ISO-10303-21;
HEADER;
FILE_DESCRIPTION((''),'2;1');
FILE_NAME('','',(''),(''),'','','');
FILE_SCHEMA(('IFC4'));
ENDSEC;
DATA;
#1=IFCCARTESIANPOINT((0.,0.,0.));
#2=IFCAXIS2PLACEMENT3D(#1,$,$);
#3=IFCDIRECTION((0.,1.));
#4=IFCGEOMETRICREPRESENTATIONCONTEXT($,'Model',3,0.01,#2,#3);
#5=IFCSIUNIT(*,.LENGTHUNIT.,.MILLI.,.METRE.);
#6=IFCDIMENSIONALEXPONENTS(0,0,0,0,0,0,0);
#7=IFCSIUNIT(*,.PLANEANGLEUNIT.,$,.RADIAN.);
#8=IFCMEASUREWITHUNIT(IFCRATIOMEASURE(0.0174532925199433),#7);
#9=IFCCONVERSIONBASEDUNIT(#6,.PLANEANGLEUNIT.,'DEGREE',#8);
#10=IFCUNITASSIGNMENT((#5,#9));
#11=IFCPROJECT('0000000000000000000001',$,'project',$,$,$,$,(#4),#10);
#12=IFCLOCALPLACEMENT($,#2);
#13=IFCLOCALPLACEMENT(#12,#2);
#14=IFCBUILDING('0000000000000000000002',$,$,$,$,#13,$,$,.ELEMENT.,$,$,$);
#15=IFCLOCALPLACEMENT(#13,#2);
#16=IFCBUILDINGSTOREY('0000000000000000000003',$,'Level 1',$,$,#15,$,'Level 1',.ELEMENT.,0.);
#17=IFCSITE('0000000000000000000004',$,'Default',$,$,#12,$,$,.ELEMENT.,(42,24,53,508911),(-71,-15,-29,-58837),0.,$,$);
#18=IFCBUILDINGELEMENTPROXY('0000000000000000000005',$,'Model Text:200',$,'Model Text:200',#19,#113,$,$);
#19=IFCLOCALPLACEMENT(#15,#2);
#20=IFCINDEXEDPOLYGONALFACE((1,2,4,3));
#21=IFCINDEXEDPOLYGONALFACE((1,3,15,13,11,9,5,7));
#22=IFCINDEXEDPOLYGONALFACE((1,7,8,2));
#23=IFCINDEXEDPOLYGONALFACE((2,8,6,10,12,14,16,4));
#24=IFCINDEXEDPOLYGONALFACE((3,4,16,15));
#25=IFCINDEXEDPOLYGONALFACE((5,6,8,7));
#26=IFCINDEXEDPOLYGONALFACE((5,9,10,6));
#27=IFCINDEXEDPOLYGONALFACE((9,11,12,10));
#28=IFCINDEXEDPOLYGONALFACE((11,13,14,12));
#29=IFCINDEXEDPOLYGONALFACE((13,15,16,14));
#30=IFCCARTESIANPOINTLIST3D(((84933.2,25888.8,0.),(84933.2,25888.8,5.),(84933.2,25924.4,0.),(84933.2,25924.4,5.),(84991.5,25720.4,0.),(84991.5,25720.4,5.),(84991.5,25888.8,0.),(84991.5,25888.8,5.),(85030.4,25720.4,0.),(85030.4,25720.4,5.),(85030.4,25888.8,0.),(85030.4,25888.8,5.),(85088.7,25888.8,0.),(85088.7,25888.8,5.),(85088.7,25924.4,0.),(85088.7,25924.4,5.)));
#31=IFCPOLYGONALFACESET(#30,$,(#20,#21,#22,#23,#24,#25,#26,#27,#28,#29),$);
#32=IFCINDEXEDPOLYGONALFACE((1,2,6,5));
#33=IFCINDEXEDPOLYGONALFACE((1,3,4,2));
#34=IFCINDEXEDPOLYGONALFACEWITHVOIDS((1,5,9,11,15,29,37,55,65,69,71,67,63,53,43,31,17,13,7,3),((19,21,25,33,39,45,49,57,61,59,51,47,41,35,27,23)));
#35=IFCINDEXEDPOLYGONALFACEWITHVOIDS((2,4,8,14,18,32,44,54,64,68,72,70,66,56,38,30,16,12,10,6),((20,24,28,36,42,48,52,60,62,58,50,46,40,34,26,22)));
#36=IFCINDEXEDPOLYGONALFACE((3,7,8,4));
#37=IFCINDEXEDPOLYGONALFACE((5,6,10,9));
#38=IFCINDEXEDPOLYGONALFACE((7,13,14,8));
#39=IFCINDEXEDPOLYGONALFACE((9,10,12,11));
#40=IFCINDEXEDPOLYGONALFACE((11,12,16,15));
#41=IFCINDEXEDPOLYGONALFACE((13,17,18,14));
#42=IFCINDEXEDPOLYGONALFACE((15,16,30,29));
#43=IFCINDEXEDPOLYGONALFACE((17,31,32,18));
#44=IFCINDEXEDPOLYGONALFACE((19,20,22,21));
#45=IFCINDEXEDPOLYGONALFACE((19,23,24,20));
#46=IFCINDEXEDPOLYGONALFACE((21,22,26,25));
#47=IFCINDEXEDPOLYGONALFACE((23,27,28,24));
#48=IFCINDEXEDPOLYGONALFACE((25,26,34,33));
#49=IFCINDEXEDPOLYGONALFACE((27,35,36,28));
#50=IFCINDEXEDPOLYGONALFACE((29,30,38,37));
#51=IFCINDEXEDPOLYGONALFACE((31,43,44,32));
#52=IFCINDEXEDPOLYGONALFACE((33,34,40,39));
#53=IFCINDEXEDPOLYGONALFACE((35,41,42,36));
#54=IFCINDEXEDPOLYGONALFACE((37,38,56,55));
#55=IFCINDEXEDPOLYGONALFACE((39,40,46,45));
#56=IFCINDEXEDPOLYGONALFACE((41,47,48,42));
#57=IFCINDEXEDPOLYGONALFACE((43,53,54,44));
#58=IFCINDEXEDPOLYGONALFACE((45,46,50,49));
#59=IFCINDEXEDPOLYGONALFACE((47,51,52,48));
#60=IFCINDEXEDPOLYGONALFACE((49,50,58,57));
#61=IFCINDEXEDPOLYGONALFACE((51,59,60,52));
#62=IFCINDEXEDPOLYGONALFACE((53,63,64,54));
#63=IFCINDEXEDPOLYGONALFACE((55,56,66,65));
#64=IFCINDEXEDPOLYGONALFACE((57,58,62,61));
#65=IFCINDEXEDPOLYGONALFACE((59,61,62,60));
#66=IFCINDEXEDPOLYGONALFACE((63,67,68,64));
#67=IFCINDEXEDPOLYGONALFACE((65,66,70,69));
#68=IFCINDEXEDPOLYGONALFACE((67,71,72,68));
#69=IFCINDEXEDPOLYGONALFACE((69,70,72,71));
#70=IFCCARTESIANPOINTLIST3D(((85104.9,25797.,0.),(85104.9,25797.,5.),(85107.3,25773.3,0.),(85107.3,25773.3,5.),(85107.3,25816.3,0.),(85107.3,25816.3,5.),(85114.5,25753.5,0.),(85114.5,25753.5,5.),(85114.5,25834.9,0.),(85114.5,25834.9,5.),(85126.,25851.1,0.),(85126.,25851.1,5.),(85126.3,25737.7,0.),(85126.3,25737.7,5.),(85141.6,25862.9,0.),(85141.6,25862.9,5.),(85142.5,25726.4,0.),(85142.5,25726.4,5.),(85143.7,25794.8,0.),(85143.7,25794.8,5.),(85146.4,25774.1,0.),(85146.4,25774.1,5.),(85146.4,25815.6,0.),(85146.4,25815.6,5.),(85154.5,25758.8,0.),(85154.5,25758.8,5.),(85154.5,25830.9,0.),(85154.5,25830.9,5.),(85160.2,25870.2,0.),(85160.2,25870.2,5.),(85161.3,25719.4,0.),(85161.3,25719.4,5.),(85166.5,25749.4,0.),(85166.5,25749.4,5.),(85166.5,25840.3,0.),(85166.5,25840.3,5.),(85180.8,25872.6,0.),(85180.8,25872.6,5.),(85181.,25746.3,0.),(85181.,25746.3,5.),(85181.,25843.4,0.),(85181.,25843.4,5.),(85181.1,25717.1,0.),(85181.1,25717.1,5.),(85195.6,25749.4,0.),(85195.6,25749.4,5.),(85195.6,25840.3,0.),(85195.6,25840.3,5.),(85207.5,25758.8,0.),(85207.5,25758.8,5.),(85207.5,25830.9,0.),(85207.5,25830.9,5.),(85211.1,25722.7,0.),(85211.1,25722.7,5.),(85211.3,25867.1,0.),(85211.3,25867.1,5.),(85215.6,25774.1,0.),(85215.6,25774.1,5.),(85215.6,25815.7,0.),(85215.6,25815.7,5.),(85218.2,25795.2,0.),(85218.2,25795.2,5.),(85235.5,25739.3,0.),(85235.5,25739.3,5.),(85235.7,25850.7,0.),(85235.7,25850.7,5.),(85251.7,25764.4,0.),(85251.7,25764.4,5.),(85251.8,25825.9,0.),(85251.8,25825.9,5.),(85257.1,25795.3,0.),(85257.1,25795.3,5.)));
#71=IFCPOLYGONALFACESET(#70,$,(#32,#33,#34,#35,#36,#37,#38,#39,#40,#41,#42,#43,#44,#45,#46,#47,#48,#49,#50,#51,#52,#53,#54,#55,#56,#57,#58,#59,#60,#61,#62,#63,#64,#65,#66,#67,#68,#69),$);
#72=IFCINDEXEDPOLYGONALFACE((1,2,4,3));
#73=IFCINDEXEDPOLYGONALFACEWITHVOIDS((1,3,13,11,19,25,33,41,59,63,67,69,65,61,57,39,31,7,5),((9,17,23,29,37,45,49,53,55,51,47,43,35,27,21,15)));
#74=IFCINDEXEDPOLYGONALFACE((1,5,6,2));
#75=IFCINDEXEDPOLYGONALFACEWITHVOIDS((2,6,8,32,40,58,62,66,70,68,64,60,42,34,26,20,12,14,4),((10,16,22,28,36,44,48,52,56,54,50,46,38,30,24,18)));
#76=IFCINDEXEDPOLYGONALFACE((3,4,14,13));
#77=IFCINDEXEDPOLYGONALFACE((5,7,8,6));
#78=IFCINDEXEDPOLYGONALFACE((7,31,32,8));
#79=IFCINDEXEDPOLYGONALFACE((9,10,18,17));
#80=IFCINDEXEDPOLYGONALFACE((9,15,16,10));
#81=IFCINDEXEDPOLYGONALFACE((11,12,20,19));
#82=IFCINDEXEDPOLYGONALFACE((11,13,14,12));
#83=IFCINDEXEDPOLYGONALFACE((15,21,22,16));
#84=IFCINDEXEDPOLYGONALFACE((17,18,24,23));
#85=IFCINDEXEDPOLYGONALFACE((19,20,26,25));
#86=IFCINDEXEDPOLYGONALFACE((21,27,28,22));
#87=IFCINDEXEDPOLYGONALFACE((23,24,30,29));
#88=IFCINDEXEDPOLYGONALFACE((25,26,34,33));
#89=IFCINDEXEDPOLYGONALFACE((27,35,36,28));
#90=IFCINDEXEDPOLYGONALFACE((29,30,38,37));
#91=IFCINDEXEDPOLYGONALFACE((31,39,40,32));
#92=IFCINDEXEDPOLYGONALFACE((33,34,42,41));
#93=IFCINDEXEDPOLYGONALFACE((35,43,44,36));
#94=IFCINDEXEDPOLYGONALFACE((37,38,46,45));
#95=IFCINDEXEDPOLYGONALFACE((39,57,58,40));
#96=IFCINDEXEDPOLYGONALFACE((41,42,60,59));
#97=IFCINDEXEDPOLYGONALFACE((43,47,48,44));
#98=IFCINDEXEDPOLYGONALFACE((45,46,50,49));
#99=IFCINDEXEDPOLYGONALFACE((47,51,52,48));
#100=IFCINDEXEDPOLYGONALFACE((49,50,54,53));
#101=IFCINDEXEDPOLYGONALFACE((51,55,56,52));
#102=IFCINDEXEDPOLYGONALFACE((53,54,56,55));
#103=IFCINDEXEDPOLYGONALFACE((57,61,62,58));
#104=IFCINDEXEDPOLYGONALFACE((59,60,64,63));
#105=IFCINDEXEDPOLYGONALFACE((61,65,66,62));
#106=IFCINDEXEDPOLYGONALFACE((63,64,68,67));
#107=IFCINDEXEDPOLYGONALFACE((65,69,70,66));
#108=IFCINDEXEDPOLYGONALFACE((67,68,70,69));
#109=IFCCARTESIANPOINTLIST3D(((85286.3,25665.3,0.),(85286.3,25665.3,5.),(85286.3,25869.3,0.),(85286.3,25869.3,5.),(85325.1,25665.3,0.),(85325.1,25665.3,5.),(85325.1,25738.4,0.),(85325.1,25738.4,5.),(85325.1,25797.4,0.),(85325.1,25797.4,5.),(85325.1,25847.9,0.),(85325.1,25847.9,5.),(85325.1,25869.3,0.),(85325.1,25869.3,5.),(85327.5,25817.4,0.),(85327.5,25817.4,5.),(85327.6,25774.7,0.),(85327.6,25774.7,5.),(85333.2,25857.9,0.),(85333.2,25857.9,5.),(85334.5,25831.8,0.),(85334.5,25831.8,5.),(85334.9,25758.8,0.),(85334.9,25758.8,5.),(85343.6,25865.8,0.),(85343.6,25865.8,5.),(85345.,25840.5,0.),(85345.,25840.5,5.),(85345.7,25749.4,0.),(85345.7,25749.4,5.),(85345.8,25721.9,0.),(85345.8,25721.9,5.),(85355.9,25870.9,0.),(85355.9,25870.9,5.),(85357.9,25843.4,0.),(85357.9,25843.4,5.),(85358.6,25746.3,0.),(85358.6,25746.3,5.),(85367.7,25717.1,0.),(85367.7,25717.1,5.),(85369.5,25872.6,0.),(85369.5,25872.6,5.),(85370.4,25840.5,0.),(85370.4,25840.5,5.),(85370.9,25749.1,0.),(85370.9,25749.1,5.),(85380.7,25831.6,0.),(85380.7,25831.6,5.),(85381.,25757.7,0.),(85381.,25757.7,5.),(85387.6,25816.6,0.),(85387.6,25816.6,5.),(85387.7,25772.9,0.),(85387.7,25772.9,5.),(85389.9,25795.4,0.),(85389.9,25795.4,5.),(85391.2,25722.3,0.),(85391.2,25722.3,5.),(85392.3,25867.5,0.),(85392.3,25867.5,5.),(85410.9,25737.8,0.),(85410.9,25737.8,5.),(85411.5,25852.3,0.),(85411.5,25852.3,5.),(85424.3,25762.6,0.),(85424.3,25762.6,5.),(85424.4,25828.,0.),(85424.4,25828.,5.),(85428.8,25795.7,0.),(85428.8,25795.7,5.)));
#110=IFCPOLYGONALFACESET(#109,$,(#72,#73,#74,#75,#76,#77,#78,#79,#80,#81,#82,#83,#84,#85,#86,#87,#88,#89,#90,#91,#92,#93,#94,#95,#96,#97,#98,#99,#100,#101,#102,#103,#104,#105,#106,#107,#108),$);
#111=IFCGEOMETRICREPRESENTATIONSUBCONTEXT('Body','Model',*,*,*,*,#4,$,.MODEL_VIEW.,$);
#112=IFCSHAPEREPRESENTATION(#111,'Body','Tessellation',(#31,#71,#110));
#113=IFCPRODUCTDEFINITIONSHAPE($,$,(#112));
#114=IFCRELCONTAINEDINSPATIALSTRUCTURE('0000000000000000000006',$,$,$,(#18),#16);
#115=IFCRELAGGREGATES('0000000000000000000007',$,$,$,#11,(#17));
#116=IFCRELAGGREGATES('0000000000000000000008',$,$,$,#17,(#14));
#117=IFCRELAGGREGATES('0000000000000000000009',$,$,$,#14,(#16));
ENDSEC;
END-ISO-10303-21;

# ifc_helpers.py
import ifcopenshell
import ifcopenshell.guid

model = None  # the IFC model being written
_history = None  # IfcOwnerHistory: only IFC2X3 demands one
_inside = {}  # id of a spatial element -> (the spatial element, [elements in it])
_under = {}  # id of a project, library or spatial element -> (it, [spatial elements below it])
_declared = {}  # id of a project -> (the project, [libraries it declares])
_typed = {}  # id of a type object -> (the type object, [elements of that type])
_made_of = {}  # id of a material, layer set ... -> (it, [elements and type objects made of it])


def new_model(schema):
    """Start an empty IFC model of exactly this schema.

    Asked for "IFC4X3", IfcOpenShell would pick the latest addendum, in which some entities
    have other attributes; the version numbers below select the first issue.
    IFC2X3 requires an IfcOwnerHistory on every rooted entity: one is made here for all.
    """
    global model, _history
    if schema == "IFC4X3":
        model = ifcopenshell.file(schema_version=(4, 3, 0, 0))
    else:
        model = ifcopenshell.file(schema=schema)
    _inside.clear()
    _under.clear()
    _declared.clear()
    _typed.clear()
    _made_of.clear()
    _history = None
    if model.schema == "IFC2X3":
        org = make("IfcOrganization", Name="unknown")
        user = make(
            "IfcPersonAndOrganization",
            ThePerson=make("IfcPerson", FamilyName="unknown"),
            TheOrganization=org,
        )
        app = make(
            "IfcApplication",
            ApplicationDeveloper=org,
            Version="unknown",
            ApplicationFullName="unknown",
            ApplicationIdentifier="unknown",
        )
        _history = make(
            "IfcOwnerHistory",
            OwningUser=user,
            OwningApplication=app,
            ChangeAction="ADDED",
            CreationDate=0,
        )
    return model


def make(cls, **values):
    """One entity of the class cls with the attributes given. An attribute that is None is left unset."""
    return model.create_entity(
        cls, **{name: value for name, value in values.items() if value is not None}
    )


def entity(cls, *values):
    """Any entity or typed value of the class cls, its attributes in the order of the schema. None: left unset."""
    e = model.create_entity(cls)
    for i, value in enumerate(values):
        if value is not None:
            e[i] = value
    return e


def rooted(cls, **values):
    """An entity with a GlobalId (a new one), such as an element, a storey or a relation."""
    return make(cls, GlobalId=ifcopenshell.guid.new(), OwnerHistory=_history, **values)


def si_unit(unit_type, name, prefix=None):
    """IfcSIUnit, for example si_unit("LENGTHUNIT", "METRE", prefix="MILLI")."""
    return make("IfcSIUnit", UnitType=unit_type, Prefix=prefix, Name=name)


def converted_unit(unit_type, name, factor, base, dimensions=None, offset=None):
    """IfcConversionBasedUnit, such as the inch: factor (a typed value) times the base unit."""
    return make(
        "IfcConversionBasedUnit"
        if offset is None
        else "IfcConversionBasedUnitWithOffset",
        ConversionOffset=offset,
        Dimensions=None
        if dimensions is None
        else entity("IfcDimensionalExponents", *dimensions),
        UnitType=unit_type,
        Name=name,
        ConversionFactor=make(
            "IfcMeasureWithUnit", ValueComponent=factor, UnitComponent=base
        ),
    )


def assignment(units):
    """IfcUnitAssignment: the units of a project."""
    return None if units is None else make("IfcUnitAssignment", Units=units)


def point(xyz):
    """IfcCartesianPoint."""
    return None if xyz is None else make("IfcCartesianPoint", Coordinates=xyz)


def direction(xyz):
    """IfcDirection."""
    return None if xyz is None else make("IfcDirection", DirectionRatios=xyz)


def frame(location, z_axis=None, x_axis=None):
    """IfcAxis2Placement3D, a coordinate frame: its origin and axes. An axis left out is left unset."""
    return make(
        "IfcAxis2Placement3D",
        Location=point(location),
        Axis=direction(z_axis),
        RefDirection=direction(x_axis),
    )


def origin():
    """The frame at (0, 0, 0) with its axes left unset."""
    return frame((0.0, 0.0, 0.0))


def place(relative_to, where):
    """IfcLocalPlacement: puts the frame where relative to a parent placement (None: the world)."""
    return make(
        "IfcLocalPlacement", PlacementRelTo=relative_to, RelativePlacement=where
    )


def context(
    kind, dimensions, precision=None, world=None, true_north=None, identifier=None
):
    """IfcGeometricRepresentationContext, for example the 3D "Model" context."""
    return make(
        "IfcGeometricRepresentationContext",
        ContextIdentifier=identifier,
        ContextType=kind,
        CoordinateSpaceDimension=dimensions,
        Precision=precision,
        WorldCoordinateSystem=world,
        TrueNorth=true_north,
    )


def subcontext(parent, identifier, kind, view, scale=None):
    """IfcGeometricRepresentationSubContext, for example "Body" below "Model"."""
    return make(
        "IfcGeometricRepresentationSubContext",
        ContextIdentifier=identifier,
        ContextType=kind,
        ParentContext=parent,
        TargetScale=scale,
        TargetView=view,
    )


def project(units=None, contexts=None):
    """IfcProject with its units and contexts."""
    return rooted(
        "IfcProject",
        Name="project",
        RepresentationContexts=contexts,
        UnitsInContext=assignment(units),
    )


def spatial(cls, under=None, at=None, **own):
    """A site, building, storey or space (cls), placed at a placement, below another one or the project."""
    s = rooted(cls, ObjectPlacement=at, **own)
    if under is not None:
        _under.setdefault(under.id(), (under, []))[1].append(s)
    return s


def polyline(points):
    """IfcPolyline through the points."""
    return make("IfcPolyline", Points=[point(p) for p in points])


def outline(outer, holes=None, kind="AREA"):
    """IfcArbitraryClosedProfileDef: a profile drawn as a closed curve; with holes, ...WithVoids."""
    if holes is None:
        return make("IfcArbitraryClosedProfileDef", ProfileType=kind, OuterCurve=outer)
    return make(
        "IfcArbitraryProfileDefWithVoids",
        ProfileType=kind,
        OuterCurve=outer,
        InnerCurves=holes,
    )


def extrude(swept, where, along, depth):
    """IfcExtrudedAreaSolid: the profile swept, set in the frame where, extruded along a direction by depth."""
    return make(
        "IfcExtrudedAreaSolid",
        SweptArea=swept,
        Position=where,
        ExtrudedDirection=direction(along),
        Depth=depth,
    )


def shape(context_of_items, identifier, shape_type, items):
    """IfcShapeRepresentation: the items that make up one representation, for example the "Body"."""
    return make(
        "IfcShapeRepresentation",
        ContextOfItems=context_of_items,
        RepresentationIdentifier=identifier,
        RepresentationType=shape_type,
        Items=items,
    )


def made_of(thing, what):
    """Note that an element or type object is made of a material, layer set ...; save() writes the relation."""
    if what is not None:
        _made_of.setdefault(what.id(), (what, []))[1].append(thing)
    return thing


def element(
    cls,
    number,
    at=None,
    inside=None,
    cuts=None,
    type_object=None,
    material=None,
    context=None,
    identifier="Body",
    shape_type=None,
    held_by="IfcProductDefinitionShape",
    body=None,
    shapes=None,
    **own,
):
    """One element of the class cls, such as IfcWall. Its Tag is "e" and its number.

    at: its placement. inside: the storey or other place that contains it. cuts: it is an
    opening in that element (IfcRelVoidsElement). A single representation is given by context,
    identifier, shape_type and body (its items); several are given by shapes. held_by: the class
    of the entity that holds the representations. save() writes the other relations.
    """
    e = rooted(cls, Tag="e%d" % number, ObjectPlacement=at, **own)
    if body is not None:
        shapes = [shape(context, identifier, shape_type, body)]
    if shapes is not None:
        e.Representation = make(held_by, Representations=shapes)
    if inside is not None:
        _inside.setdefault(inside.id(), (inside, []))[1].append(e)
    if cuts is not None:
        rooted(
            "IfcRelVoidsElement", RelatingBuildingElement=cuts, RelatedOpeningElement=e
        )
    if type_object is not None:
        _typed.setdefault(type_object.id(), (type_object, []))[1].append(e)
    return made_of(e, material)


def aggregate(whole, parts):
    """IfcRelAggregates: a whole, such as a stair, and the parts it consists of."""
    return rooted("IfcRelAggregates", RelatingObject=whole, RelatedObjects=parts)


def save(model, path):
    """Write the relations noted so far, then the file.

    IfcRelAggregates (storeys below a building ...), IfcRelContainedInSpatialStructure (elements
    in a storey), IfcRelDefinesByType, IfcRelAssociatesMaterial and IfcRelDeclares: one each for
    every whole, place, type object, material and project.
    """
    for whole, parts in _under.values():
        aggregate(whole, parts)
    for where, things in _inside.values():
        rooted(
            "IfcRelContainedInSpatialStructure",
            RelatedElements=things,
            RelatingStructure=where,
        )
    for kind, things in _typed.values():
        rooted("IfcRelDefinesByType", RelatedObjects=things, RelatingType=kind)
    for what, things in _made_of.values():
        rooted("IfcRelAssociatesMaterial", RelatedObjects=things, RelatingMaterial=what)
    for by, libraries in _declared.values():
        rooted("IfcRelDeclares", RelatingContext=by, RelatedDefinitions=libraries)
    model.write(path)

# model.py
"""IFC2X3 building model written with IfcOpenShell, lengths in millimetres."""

from ifc_helpers import new_model, entity, si_unit, converted_unit, direction, frame, origin, place, context, subcontext, project, spatial, polyline, outline, extrude, element, save


model = new_model("IFC2X3")

# Units and contexts
model_context = context("Model", 3, precision=0.01, world=origin(), true_north=direction((0.0, 1.0)))
body_context = subcontext(model_context, "Body", "Model", "MODEL_VIEW")
ifc_project = project(units=[si_unit("LENGTHUNIT", "METRE", prefix="MILLI"), converted_unit("PLANEANGLEUNIT", "DEGREE", entity("IfcRatioMeasure", 0.0174532925199433), si_unit("PLANEANGLEUNIT", "RADIAN"), dimensions=[0, 0, 0, 0, 0, 0, 0])], contexts=[model_context])

# Site, building, storey
site_placement = place(None, origin())
site = spatial("IfcSite", under=ifc_project, at=site_placement, Name="Default", CompositionType="ELEMENT", RefLatitude=(42, 24, 53, 508911), RefLongitude=(-71, -15, -29, -58837), RefElevation=0.0)
building_placement = place(site_placement, origin())
building = spatial("IfcBuilding", under=site, at=building_placement, CompositionType="ELEMENT")
storey_placement = place(building_placement, origin())
storey = spatial("IfcBuildingStorey", under=building, at=storey_placement, Name="Level 1", LongName="Level 1", CompositionType="ELEMENT", Elevation=0.0)

# Building element proxy
proxy_1_placement = place(storey_placement, origin())
element("IfcBuildingElementProxy", 1, at=proxy_1_placement, inside=storey, Name="Model Text:200", ObjectType="Model Text:200", context=body_context, shape_type="SweptSolid", body=[
    extrude(outline(polyline([(-19.4, -135.2), (19.4, -135.2), (19.4, 33.2), (77.7, 33.2), (77.7, 68.8), (-77.7, 68.8), (-77.7, 33.2), (-19.4, 33.2), (-19.4, -135.2)])), frame((85010.9, 25855.6, 0.0)), (0.0, 0.0, 1.0), 5.0),
    extrude(outline(polyline([(-8.8, -65.7), (15.1, -65.7), (35.5, -60.5), (52.3, -50.4), (65.3, -35.4), (74.1, -17.3), (78.4, 2.1), (75.9, 32.5), (61.8, 58.5), (38.4, 77.1), (8.3, 85.6), (-22.7, 83.3), (-49.0, 69.9), (-67.8, 47.3), (-76.3, 17.5), (-76.0, -3.3), (-70.7, -22.5), (-60.5, -39.2), (-45.5, -52.3), (-27.7, -61.4), (-8.8, -65.7)]), holes=[polyline([(-2.7, -27.2), (-23.1, -22.5), (-37.5, -12.9), (-45.7, 0.0), (-47.3, 14.8), (-42.7, 28.9), (-32.2, 39.9), (-16.3, 46.3), (4.5, 46.9), (25.1, 42.1), (39.6, 32.6), (47.7, 19.7), (49.4, 5.0), (44.8, -9.2), (34.2, -20.2), (18.2, -26.7), (-2.7, -27.2)])]), frame((85171.1, 25794.9, 0.0), z_axis=(0.0, 0.0, 1.0), x_axis=(0.100608, -0.994926, 0.0)), (0.0, 0.0, 1.0), 5.0),
    extrude(outline(polyline([(-73.1, -75.4), (130.9, -75.4), (130.9, -36.6), (57.8, -36.6), (74.3, -15.9), (79.1, 6.0), (73.9, 29.5), (58.4, 49.2), (33.6, 62.6), (0.5, 67.1), (-31.8, 62.8), (-56.1, 49.8), (-71.3, 30.7), (-76.4, 7.8), (-74.7, -5.8), (-69.6, -18.1), (-61.7, -28.5), (-51.7, -36.6), (-73.1, -36.6), (-73.1, -75.4)]), holes=[polyline([(-1.2, -36.6), (-21.2, -34.2), (-35.6, -27.2), (-44.3, -16.7), (-47.2, -3.8), (-44.3, 8.7), (-35.4, 19.0), (-20.4, 25.9), (0.8, 28.2), (23.3, 26.0), (38.5, 19.3), (47.1, 9.2), (49.9, -3.1), (46.8, -16.0), (37.4, -26.8), (21.5, -34.1), (-1.2, -36.6)])]), frame((85361.7, 25796.2, 0.0), z_axis=(0.0, 0.0, 1.0), x_axis=(0.0, -1.0, 0.0)), (0.0, 0.0, 1.0), 5.0),
])

save(model, "model.ifc")
